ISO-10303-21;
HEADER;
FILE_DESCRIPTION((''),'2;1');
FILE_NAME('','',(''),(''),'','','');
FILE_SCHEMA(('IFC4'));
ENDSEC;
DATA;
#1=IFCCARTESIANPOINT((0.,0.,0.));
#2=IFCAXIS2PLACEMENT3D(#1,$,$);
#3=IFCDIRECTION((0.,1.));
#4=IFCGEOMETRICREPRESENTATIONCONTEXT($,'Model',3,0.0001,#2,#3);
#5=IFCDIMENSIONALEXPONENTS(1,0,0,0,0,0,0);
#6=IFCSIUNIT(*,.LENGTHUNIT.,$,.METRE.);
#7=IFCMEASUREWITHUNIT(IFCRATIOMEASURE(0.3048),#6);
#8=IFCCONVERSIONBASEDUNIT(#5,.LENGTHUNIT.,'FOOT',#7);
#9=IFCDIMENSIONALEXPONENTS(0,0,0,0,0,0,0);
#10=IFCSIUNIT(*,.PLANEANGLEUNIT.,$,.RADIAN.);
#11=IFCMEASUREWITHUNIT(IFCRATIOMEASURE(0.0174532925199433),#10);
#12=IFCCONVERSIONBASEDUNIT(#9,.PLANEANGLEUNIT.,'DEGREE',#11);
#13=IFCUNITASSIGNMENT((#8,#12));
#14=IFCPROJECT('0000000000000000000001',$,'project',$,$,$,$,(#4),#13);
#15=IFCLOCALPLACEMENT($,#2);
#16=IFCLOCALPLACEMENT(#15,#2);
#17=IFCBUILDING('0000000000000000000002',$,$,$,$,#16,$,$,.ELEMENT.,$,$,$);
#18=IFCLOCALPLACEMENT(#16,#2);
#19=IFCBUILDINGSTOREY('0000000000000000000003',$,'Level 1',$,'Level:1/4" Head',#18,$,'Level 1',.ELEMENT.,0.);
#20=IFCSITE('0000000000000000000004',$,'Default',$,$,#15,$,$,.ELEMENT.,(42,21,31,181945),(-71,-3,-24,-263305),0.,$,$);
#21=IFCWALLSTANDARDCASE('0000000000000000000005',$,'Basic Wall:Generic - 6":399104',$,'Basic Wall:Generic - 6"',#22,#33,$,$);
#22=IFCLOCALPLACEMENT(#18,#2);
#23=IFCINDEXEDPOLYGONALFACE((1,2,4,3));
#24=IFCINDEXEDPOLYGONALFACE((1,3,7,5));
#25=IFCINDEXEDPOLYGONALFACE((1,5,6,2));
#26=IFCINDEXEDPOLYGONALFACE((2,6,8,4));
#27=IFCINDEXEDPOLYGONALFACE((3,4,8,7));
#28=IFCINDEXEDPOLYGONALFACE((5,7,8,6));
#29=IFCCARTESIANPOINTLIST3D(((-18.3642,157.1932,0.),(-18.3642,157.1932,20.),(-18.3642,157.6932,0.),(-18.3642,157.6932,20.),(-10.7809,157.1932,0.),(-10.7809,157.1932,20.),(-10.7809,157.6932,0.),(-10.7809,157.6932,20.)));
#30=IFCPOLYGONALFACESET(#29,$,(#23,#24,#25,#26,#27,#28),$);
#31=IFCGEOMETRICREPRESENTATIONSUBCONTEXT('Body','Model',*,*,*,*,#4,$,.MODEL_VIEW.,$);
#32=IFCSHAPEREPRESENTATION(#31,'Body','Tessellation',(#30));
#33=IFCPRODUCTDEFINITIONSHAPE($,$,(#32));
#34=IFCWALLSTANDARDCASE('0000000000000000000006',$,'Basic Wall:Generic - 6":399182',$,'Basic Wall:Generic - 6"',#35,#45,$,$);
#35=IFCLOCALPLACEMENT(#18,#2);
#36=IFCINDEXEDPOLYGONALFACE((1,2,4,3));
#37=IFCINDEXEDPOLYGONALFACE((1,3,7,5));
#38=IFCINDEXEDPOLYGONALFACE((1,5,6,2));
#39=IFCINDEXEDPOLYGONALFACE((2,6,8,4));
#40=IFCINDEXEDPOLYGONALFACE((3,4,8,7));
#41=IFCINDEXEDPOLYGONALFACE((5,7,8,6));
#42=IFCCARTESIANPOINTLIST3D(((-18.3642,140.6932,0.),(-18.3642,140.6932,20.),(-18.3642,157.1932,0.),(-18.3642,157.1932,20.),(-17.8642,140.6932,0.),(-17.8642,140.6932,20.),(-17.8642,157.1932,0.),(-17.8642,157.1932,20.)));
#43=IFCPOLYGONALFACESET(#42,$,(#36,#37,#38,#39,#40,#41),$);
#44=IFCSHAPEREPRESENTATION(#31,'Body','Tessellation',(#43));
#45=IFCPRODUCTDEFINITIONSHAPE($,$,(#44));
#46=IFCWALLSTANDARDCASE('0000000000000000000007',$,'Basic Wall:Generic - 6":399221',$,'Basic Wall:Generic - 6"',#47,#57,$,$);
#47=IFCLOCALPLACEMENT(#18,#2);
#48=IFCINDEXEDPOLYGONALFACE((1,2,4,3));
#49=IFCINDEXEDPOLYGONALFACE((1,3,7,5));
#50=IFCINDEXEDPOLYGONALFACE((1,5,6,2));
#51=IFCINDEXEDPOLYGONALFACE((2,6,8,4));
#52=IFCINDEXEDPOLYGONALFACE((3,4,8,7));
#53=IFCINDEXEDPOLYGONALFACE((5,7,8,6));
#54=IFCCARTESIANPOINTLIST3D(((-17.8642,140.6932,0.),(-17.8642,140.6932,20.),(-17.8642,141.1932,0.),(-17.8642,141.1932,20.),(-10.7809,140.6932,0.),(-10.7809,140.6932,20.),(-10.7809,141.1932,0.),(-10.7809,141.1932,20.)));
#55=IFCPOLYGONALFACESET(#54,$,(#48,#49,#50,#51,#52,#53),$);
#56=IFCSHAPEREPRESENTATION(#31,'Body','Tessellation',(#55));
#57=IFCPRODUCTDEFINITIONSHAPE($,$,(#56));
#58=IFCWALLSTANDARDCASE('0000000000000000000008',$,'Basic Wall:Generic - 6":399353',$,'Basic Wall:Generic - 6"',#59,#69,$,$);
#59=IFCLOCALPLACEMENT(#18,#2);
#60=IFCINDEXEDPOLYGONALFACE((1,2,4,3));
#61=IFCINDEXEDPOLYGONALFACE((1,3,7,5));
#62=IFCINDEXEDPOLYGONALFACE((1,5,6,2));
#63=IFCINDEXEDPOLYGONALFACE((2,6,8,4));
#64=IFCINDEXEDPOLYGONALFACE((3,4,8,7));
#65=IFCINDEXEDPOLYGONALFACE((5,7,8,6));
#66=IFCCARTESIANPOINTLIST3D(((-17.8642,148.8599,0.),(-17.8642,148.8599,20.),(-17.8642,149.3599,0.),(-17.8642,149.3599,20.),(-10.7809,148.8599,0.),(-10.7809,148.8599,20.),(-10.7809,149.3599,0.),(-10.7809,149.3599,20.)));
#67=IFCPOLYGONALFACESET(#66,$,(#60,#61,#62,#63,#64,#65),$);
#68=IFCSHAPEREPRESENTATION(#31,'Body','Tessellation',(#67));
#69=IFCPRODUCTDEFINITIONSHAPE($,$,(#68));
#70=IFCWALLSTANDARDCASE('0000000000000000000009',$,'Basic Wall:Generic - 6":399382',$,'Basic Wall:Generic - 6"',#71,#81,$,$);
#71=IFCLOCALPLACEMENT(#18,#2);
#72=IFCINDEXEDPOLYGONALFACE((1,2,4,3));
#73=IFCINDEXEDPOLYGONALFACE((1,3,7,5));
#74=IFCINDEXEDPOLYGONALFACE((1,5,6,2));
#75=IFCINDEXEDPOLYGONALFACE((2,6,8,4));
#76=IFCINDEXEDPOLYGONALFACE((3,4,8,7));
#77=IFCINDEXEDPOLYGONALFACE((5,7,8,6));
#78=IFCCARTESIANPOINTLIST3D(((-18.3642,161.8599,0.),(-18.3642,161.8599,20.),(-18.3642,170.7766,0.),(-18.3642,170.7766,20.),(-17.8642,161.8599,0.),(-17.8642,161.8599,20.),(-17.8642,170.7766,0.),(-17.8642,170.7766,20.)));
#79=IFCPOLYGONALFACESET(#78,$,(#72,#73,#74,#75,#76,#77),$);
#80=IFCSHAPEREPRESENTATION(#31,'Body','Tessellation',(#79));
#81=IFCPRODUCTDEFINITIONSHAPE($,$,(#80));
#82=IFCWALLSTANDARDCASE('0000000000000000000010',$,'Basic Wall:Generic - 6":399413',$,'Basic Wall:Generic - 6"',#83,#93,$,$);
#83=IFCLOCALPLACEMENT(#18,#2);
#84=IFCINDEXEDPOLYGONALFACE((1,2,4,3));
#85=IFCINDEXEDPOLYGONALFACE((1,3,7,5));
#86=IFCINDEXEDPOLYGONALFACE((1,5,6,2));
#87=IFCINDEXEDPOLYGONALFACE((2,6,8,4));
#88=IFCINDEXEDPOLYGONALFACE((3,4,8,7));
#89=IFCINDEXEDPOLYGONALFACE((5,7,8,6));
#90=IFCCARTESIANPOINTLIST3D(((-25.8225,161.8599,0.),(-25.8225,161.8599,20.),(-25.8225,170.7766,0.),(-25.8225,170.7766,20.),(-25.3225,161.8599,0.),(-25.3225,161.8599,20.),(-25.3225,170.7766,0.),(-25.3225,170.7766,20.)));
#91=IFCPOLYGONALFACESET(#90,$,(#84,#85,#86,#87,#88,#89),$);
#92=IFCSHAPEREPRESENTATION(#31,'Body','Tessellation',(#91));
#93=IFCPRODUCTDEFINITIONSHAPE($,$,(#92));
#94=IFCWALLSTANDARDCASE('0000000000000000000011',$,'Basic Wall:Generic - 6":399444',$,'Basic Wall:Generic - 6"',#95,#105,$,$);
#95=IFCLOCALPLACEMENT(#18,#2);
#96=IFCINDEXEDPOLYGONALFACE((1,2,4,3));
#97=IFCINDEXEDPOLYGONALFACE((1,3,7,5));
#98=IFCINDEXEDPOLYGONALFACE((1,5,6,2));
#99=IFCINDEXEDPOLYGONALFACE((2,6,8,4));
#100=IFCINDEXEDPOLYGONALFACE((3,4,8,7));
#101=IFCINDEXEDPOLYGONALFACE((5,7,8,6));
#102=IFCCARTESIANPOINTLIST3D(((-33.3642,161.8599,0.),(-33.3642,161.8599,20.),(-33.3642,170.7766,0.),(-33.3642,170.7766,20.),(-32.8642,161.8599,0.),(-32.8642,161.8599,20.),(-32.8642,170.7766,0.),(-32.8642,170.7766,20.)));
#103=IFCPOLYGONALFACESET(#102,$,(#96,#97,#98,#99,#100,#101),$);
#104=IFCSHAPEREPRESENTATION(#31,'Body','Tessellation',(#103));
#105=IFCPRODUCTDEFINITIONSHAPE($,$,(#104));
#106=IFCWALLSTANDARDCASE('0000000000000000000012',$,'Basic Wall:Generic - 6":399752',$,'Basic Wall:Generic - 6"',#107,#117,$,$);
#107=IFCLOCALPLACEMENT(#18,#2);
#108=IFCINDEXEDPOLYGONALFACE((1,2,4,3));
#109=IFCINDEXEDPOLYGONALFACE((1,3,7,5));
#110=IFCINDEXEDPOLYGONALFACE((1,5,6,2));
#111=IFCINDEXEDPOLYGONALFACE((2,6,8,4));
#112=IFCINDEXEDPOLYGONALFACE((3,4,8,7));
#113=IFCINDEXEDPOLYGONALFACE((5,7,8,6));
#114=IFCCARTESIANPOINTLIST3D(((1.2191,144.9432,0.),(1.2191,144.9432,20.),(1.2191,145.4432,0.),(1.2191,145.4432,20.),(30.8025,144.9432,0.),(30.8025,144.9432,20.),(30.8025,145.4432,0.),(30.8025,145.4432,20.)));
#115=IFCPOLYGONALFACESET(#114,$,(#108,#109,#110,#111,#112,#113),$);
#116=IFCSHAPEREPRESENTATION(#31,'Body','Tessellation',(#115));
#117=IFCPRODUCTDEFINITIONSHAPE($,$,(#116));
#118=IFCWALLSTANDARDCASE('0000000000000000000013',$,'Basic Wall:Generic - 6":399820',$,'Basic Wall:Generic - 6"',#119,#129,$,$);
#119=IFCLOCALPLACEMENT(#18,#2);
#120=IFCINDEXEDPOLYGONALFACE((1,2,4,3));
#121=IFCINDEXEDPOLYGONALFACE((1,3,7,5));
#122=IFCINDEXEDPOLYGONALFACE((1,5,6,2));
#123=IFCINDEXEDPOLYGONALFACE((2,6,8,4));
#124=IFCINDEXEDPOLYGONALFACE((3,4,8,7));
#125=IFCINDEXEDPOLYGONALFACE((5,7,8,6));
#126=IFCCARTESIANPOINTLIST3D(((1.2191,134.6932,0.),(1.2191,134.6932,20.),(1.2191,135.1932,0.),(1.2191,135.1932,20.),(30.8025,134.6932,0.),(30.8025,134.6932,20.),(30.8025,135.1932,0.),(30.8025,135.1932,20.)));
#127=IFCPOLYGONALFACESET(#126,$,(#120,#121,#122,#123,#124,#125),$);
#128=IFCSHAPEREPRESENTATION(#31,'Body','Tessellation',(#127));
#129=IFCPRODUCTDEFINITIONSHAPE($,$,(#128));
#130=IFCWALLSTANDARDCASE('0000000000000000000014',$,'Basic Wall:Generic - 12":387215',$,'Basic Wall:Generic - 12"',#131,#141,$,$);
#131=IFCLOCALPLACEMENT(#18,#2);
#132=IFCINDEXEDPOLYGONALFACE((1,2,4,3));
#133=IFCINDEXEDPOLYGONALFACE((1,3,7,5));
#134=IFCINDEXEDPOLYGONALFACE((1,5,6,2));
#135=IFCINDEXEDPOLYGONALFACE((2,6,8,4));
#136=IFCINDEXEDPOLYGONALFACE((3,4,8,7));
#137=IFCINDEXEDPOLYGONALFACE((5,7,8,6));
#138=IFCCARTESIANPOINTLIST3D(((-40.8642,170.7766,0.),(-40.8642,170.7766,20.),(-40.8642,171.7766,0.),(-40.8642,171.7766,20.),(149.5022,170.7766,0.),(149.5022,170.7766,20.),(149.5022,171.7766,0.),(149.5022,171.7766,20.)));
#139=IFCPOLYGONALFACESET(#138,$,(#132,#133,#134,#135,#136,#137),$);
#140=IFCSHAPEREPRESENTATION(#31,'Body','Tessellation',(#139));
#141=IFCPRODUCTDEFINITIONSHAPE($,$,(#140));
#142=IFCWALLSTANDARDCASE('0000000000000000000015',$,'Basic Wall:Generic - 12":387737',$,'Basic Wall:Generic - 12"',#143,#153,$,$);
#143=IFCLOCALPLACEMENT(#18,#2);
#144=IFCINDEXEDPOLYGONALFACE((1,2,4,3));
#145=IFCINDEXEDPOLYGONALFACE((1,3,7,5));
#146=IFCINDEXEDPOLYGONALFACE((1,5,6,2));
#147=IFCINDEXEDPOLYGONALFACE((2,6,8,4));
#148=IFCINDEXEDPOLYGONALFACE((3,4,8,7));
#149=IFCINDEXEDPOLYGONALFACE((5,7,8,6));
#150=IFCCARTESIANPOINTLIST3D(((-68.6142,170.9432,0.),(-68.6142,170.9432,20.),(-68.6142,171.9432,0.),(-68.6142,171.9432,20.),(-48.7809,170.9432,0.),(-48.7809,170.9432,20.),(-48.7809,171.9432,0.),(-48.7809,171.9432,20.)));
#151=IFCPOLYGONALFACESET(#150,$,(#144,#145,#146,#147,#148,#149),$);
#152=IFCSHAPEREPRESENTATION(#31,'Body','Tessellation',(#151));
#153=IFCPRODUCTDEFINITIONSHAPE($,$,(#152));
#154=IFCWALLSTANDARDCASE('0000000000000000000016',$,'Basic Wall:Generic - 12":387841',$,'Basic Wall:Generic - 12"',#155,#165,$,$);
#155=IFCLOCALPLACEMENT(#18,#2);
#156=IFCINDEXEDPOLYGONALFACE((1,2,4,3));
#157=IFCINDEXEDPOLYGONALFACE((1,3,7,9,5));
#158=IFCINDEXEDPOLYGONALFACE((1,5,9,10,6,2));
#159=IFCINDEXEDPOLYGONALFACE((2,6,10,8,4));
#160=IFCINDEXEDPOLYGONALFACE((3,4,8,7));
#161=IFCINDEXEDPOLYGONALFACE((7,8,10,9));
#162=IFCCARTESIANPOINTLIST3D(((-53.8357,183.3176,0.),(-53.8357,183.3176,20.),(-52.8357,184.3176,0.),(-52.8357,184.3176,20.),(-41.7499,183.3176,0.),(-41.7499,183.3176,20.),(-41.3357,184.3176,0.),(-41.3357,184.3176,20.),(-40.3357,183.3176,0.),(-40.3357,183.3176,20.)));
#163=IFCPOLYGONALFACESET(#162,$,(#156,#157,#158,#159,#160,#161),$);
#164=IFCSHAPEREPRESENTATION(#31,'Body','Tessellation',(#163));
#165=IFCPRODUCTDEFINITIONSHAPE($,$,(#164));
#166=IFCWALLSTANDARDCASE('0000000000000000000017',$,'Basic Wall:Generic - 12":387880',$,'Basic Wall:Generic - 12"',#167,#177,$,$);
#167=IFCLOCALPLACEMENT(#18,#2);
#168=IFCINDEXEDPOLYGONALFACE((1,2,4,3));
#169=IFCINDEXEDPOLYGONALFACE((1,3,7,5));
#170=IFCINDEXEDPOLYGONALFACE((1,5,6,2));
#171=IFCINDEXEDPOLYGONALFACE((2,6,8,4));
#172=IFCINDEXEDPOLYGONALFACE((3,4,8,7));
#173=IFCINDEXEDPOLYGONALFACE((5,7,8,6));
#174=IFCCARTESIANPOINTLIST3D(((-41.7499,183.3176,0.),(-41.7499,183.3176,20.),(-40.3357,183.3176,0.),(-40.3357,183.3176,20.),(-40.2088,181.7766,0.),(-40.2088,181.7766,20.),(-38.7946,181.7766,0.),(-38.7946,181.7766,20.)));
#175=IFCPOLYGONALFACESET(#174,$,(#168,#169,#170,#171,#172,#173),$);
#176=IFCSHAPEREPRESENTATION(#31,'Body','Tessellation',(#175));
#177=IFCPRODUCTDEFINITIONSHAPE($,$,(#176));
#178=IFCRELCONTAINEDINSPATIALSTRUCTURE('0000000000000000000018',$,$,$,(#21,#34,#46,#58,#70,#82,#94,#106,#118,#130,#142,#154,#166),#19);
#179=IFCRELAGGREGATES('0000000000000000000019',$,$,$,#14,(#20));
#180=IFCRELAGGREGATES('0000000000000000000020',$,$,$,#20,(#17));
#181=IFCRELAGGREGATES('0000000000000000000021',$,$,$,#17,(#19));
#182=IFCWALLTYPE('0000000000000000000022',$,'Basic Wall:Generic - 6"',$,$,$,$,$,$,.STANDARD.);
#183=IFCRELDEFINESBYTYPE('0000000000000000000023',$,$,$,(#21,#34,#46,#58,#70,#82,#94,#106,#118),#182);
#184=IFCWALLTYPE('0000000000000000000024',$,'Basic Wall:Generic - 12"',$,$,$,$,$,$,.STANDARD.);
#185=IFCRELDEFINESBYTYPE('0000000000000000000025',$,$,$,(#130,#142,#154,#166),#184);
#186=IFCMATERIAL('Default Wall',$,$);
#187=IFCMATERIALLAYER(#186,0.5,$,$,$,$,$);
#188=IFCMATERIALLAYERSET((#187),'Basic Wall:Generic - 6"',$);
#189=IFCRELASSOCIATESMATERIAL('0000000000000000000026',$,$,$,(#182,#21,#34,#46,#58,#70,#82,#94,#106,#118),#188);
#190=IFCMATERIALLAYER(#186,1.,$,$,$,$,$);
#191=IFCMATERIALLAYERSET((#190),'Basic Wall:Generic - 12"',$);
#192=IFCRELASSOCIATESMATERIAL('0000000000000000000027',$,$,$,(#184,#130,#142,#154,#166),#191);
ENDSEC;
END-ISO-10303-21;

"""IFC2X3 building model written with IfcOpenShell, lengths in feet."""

from ifc_helpers import new_model, entity, si_unit, converted_unit, direction, frame, frame_2d, origin, place, context, subcontext, project, spatial, polyline, rectangle, outline, extrude, material, layer, layer_set, layer_usage, type_object, element, save


model = new_model("IFC2X3")

# Units and contexts
model_context = context("Model", 3, precision=0.0001, world=origin(), true_north=direction((0.0, 1.0)))
body_context = subcontext(model_context, "Body", "Model", "MODEL_VIEW")
ifc_project = project(units=[converted_unit("LENGTHUNIT", "FOOT", entity("IfcRatioMeasure", 0.3048), si_unit("LENGTHUNIT", "METRE"), dimensions=[1, 0, 0, 0, 0, 0, 0]), converted_unit("PLANEANGLEUNIT", "DEGREE", entity("IfcRatioMeasure", 0.0174532925199433), si_unit("PLANEANGLEUNIT", "RADIAN"), dimensions=[0, 0, 0, 0, 0, 0, 0])], contexts=[model_context])

# Site, building, storey
site_placement = place(None, origin())
site = spatial("IfcSite", under=ifc_project, at=site_placement, Name="Default", CompositionType="ELEMENT", RefLatitude=(42, 21, 31, 181945), RefLongitude=(-71, -3, -24, -263305), RefElevation=0.0)
building_placement = place(site_placement, origin())
building = spatial("IfcBuilding", under=site, at=building_placement, CompositionType="ELEMENT")
storey_placement = place(building_placement, origin())
storey = spatial("IfcBuildingStorey", under=building, at=storey_placement, Name="Level 1", ObjectType="Level:1/4\" Head", LongName="Level 1", CompositionType="ELEMENT", Elevation=0.0)

# Shared definitions
ifc_material = material(Name="Default Wall")
ifc_layer_1 = layer(ifc_material, 0.5)
ifc_layer_set_1 = layer_set([ifc_layer_1], Name="Basic Wall:Generic - 6\"")
wall_type_1 = type_object("IfcWallType", Name="Basic Wall:Generic - 6\"", PredefinedType="STANDARD", material=ifc_layer_set_1)

# Walls
ifc_layer_usage_1 = layer_usage(ifc_layer_set_1, "AXIS2", "NEGATIVE", 0.25)
wall_1_placement = place(storey_placement, frame((-10.7809, 157.4432, 0.0), z_axis=(0.0, 0.0, 1.0), x_axis=(-1.0, 0.0, 0.0)))
element("IfcWallStandardCase", 1, at=wall_1_placement, inside=storey, type_object=wall_type_1, material=ifc_layer_usage_1, Name="Basic Wall:Generic - 6\":399104", ObjectType="Basic Wall:Generic - 6\"", context=body_context, shape_type="SweptSolid", body=[
    extrude(rectangle(XDim=7.5833, YDim=0.5, at=frame_2d((3.7917, 0.0), x_axis=(-1.0, 0.0))), origin(), (0.0, 0.0, 1.0), 20.0),
])
ifc_layer_usage_2 = layer_usage(ifc_layer_set_1, "AXIS2", "NEGATIVE", 0.25)
wall_2_placement = place(storey_placement, frame((-18.1142, 157.1932, 0.0), z_axis=(0.0, 0.0, 1.0), x_axis=(0.0, -1.0, 0.0)))
element("IfcWallStandardCase", 2, at=wall_2_placement, inside=storey, type_object=wall_type_1, material=ifc_layer_usage_2, Name="Basic Wall:Generic - 6\":399182", ObjectType="Basic Wall:Generic - 6\"", context=body_context, shape_type="SweptSolid", body=[
    extrude(rectangle(XDim=16.5, YDim=0.5, at=frame_2d((8.25, 0.0), x_axis=(-1.0, 0.0))), origin(), (0.0, 0.0, 1.0), 20.0),
])
ifc_layer_usage_3 = layer_usage(ifc_layer_set_1, "AXIS2", "NEGATIVE", 0.25)
wall_3_placement = place(storey_placement, frame((-17.8642, 140.9432, 0.0)))
element("IfcWallStandardCase", 3, at=wall_3_placement, inside=storey, type_object=wall_type_1, material=ifc_layer_usage_3, Name="Basic Wall:Generic - 6\":399221", ObjectType="Basic Wall:Generic - 6\"", context=body_context, shape_type="SweptSolid", body=[
    extrude(rectangle(XDim=7.0833, YDim=0.5, at=frame_2d((3.5417, 0.0), x_axis=(-1.0, 0.0))), origin(), (0.0, 0.0, 1.0), 20.0),
])
ifc_layer_usage_4 = layer_usage(ifc_layer_set_1, "AXIS2", "NEGATIVE", 0.25)
wall_4_placement = place(storey_placement, frame((-10.7809, 149.1099, 0.0), z_axis=(0.0, 0.0, 1.0), x_axis=(-1.0, 0.0, 0.0)))
element("IfcWallStandardCase", 4, at=wall_4_placement, inside=storey, type_object=wall_type_1, material=ifc_layer_usage_4, Name="Basic Wall:Generic - 6\":399353", ObjectType="Basic Wall:Generic - 6\"", context=body_context, shape_type="SweptSolid", body=[
    extrude(rectangle(XDim=7.0833, YDim=0.5, at=frame_2d((3.5417, 0.0), x_axis=(-1.0, 0.0))), origin(), (0.0, 0.0, 1.0), 20.0),
])
ifc_layer_usage_5 = layer_usage(ifc_layer_set_1, "AXIS2", "NEGATIVE", 0.25)
wall_5_placement = place(storey_placement, frame((-18.1142, 161.8599, 0.0), z_axis=(0.0, 0.0, 1.0), x_axis=(0.0, 1.0, 0.0)))
element("IfcWallStandardCase", 5, at=wall_5_placement, inside=storey, type_object=wall_type_1, material=ifc_layer_usage_5, Name="Basic Wall:Generic - 6\":399382", ObjectType="Basic Wall:Generic - 6\"", context=body_context, shape_type="SweptSolid", body=[
    extrude(rectangle(XDim=8.9167, YDim=0.5, at=frame_2d((4.4583, 0.0), x_axis=(-1.0, 0.0))), origin(), (0.0, 0.0, 1.0), 20.0),
])
ifc_layer_usage_6 = layer_usage(ifc_layer_set_1, "AXIS2", "NEGATIVE", 0.25)
wall_6_placement = place(storey_placement, frame((-25.5725, 161.8599, 0.0), z_axis=(0.0, 0.0, 1.0), x_axis=(0.0, 1.0, 0.0)))
element("IfcWallStandardCase", 6, at=wall_6_placement, inside=storey, type_object=wall_type_1, material=ifc_layer_usage_6, Name="Basic Wall:Generic - 6\":399413", ObjectType="Basic Wall:Generic - 6\"", context=body_context, shape_type="SweptSolid", body=[
    extrude(rectangle(XDim=8.9167, YDim=0.5, at=frame_2d((4.4583, 0.0), x_axis=(-1.0, 0.0))), origin(), (0.0, 0.0, 1.0), 20.0),
])
ifc_layer_usage_7 = layer_usage(ifc_layer_set_1, "AXIS2", "NEGATIVE", 0.25)
wall_7_placement = place(storey_placement, frame((-33.1142, 170.7766, 0.0), z_axis=(0.0, 0.0, 1.0), x_axis=(0.0, -1.0, 0.0)))
element("IfcWallStandardCase", 7, at=wall_7_placement, inside=storey, type_object=wall_type_1, material=ifc_layer_usage_7, Name="Basic Wall:Generic - 6\":399444", ObjectType="Basic Wall:Generic - 6\"", context=body_context, shape_type="SweptSolid", body=[
    extrude(rectangle(XDim=8.9167, YDim=0.5, at=frame_2d((4.4583, 0.0), x_axis=(-1.0, 0.0))), origin(), (0.0, 0.0, 1.0), 20.0),
])
ifc_layer_usage_8 = layer_usage(ifc_layer_set_1, "AXIS2", "NEGATIVE", 0.25)
wall_8_placement = place(storey_placement, frame((1.2191, 145.1932, 0.0)))
element("IfcWallStandardCase", 8, at=wall_8_placement, inside=storey, type_object=wall_type_1, material=ifc_layer_usage_8, Name="Basic Wall:Generic - 6\":399752", ObjectType="Basic Wall:Generic - 6\"", context=body_context, shape_type="SweptSolid", body=[
    extrude(rectangle(XDim=29.5833, YDim=0.5, at=frame_2d((14.7917, 0.0), x_axis=(-1.0, 0.0))), origin(), (0.0, 0.0, 1.0), 20.0),
])
ifc_layer_usage_9 = layer_usage(ifc_layer_set_1, "AXIS2", "NEGATIVE", 0.25)
wall_9_placement = place(storey_placement, frame((1.2191, 134.9432, 0.0)))
element("IfcWallStandardCase", 9, at=wall_9_placement, inside=storey, type_object=wall_type_1, material=ifc_layer_usage_9, Name="Basic Wall:Generic - 6\":399820", ObjectType="Basic Wall:Generic - 6\"", context=body_context, shape_type="SweptSolid", body=[
    extrude(rectangle(XDim=29.5833, YDim=0.5, at=frame_2d((14.7917, 0.0), x_axis=(-1.0, 0.0))), origin(), (0.0, 0.0, 1.0), 20.0),
])
ifc_layer_2 = layer(ifc_material, 1.0)
ifc_layer_set_2 = layer_set([ifc_layer_2], Name="Basic Wall:Generic - 12\"")
ifc_layer_usage_10 = layer_usage(ifc_layer_set_2, "AXIS2", "NEGATIVE", 0.5)
wall_type_2 = type_object("IfcWallType", Name="Basic Wall:Generic - 12\"", PredefinedType="STANDARD", material=ifc_layer_set_2)
wall_10_placement = place(storey_placement, frame((-40.8642, 171.2766, 0.0)))
element("IfcWallStandardCase", 10, at=wall_10_placement, inside=storey, type_object=wall_type_2, material=ifc_layer_usage_10, Name="Basic Wall:Generic - 12\":387215", ObjectType="Basic Wall:Generic - 12\"", context=body_context, shape_type="SweptSolid", body=[
    extrude(rectangle(XDim=190.3664, YDim=1.0, at=frame_2d((95.1832, 0.0), x_axis=(-1.0, 0.0))), origin(), (0.0, 0.0, 1.0), 20.0),
])
ifc_layer_usage_11 = layer_usage(ifc_layer_set_2, "AXIS2", "NEGATIVE", 0.5)
wall_11_placement = place(storey_placement, frame((-48.7809, 171.4432, 0.0), z_axis=(0.0, 0.0, 1.0), x_axis=(-1.0, 0.0, 0.0)))
element("IfcWallStandardCase", 11, at=wall_11_placement, inside=storey, type_object=wall_type_2, material=ifc_layer_usage_11, Name="Basic Wall:Generic - 12\":387737", ObjectType="Basic Wall:Generic - 12\"", context=body_context, shape_type="SweptSolid", body=[
    extrude(rectangle(XDim=19.8333, YDim=1.0, at=frame_2d((9.9167, 0.0), x_axis=(-1.0, 0.0))), origin(), (0.0, 0.0, 1.0), 20.0),
])
ifc_layer_usage_12 = layer_usage(ifc_layer_set_2, "AXIS2", "NEGATIVE", 0.5)
wall_12_placement = place(storey_placement, frame((-53.8357, 183.8176, 0.0)))
element("IfcWallStandardCase", 12, at=wall_12_placement, inside=storey, type_object=wall_type_2, material=ifc_layer_usage_12, Name="Basic Wall:Generic - 12\":387841", ObjectType="Basic Wall:Generic - 12\"", context=body_context, shape_type="SweptSolid", body=[
    extrude(outline(polyline([(13.5, -0.5), (12.5, 0.5), (1.0, 0.5), (0.0, -0.5), (12.0858, -0.5), (13.5, -0.5)])), origin(), (0.0, 0.0, 1.0), 20.0),
])
ifc_layer_usage_13 = layer_usage(ifc_layer_set_2, "AXIS2", "NEGATIVE", 0.5)
wall_13_placement = place(storey_placement, frame((-41.3963, 183.6712, 0.0), z_axis=(0.0, 0.0, 1.0), x_axis=(0.707107, -0.707107, 0.0)))
element("IfcWallStandardCase", 13, at=wall_13_placement, inside=storey, type_object=wall_type_2, material=ifc_layer_usage_13, Name="Basic Wall:Generic - 12\":387880", ObjectType="Basic Wall:Generic - 12\"", context=body_context, shape_type="SweptSolid", body=[
    extrude(outline(polyline([(2.1794, -0.5), (3.1794, 0.5), (1.0, 0.5), (0.0, -0.5), (2.1794, -0.5)])), origin(), (0.0, 0.0, 1.0), 20.0),
])

save(model, "model.ifc")
